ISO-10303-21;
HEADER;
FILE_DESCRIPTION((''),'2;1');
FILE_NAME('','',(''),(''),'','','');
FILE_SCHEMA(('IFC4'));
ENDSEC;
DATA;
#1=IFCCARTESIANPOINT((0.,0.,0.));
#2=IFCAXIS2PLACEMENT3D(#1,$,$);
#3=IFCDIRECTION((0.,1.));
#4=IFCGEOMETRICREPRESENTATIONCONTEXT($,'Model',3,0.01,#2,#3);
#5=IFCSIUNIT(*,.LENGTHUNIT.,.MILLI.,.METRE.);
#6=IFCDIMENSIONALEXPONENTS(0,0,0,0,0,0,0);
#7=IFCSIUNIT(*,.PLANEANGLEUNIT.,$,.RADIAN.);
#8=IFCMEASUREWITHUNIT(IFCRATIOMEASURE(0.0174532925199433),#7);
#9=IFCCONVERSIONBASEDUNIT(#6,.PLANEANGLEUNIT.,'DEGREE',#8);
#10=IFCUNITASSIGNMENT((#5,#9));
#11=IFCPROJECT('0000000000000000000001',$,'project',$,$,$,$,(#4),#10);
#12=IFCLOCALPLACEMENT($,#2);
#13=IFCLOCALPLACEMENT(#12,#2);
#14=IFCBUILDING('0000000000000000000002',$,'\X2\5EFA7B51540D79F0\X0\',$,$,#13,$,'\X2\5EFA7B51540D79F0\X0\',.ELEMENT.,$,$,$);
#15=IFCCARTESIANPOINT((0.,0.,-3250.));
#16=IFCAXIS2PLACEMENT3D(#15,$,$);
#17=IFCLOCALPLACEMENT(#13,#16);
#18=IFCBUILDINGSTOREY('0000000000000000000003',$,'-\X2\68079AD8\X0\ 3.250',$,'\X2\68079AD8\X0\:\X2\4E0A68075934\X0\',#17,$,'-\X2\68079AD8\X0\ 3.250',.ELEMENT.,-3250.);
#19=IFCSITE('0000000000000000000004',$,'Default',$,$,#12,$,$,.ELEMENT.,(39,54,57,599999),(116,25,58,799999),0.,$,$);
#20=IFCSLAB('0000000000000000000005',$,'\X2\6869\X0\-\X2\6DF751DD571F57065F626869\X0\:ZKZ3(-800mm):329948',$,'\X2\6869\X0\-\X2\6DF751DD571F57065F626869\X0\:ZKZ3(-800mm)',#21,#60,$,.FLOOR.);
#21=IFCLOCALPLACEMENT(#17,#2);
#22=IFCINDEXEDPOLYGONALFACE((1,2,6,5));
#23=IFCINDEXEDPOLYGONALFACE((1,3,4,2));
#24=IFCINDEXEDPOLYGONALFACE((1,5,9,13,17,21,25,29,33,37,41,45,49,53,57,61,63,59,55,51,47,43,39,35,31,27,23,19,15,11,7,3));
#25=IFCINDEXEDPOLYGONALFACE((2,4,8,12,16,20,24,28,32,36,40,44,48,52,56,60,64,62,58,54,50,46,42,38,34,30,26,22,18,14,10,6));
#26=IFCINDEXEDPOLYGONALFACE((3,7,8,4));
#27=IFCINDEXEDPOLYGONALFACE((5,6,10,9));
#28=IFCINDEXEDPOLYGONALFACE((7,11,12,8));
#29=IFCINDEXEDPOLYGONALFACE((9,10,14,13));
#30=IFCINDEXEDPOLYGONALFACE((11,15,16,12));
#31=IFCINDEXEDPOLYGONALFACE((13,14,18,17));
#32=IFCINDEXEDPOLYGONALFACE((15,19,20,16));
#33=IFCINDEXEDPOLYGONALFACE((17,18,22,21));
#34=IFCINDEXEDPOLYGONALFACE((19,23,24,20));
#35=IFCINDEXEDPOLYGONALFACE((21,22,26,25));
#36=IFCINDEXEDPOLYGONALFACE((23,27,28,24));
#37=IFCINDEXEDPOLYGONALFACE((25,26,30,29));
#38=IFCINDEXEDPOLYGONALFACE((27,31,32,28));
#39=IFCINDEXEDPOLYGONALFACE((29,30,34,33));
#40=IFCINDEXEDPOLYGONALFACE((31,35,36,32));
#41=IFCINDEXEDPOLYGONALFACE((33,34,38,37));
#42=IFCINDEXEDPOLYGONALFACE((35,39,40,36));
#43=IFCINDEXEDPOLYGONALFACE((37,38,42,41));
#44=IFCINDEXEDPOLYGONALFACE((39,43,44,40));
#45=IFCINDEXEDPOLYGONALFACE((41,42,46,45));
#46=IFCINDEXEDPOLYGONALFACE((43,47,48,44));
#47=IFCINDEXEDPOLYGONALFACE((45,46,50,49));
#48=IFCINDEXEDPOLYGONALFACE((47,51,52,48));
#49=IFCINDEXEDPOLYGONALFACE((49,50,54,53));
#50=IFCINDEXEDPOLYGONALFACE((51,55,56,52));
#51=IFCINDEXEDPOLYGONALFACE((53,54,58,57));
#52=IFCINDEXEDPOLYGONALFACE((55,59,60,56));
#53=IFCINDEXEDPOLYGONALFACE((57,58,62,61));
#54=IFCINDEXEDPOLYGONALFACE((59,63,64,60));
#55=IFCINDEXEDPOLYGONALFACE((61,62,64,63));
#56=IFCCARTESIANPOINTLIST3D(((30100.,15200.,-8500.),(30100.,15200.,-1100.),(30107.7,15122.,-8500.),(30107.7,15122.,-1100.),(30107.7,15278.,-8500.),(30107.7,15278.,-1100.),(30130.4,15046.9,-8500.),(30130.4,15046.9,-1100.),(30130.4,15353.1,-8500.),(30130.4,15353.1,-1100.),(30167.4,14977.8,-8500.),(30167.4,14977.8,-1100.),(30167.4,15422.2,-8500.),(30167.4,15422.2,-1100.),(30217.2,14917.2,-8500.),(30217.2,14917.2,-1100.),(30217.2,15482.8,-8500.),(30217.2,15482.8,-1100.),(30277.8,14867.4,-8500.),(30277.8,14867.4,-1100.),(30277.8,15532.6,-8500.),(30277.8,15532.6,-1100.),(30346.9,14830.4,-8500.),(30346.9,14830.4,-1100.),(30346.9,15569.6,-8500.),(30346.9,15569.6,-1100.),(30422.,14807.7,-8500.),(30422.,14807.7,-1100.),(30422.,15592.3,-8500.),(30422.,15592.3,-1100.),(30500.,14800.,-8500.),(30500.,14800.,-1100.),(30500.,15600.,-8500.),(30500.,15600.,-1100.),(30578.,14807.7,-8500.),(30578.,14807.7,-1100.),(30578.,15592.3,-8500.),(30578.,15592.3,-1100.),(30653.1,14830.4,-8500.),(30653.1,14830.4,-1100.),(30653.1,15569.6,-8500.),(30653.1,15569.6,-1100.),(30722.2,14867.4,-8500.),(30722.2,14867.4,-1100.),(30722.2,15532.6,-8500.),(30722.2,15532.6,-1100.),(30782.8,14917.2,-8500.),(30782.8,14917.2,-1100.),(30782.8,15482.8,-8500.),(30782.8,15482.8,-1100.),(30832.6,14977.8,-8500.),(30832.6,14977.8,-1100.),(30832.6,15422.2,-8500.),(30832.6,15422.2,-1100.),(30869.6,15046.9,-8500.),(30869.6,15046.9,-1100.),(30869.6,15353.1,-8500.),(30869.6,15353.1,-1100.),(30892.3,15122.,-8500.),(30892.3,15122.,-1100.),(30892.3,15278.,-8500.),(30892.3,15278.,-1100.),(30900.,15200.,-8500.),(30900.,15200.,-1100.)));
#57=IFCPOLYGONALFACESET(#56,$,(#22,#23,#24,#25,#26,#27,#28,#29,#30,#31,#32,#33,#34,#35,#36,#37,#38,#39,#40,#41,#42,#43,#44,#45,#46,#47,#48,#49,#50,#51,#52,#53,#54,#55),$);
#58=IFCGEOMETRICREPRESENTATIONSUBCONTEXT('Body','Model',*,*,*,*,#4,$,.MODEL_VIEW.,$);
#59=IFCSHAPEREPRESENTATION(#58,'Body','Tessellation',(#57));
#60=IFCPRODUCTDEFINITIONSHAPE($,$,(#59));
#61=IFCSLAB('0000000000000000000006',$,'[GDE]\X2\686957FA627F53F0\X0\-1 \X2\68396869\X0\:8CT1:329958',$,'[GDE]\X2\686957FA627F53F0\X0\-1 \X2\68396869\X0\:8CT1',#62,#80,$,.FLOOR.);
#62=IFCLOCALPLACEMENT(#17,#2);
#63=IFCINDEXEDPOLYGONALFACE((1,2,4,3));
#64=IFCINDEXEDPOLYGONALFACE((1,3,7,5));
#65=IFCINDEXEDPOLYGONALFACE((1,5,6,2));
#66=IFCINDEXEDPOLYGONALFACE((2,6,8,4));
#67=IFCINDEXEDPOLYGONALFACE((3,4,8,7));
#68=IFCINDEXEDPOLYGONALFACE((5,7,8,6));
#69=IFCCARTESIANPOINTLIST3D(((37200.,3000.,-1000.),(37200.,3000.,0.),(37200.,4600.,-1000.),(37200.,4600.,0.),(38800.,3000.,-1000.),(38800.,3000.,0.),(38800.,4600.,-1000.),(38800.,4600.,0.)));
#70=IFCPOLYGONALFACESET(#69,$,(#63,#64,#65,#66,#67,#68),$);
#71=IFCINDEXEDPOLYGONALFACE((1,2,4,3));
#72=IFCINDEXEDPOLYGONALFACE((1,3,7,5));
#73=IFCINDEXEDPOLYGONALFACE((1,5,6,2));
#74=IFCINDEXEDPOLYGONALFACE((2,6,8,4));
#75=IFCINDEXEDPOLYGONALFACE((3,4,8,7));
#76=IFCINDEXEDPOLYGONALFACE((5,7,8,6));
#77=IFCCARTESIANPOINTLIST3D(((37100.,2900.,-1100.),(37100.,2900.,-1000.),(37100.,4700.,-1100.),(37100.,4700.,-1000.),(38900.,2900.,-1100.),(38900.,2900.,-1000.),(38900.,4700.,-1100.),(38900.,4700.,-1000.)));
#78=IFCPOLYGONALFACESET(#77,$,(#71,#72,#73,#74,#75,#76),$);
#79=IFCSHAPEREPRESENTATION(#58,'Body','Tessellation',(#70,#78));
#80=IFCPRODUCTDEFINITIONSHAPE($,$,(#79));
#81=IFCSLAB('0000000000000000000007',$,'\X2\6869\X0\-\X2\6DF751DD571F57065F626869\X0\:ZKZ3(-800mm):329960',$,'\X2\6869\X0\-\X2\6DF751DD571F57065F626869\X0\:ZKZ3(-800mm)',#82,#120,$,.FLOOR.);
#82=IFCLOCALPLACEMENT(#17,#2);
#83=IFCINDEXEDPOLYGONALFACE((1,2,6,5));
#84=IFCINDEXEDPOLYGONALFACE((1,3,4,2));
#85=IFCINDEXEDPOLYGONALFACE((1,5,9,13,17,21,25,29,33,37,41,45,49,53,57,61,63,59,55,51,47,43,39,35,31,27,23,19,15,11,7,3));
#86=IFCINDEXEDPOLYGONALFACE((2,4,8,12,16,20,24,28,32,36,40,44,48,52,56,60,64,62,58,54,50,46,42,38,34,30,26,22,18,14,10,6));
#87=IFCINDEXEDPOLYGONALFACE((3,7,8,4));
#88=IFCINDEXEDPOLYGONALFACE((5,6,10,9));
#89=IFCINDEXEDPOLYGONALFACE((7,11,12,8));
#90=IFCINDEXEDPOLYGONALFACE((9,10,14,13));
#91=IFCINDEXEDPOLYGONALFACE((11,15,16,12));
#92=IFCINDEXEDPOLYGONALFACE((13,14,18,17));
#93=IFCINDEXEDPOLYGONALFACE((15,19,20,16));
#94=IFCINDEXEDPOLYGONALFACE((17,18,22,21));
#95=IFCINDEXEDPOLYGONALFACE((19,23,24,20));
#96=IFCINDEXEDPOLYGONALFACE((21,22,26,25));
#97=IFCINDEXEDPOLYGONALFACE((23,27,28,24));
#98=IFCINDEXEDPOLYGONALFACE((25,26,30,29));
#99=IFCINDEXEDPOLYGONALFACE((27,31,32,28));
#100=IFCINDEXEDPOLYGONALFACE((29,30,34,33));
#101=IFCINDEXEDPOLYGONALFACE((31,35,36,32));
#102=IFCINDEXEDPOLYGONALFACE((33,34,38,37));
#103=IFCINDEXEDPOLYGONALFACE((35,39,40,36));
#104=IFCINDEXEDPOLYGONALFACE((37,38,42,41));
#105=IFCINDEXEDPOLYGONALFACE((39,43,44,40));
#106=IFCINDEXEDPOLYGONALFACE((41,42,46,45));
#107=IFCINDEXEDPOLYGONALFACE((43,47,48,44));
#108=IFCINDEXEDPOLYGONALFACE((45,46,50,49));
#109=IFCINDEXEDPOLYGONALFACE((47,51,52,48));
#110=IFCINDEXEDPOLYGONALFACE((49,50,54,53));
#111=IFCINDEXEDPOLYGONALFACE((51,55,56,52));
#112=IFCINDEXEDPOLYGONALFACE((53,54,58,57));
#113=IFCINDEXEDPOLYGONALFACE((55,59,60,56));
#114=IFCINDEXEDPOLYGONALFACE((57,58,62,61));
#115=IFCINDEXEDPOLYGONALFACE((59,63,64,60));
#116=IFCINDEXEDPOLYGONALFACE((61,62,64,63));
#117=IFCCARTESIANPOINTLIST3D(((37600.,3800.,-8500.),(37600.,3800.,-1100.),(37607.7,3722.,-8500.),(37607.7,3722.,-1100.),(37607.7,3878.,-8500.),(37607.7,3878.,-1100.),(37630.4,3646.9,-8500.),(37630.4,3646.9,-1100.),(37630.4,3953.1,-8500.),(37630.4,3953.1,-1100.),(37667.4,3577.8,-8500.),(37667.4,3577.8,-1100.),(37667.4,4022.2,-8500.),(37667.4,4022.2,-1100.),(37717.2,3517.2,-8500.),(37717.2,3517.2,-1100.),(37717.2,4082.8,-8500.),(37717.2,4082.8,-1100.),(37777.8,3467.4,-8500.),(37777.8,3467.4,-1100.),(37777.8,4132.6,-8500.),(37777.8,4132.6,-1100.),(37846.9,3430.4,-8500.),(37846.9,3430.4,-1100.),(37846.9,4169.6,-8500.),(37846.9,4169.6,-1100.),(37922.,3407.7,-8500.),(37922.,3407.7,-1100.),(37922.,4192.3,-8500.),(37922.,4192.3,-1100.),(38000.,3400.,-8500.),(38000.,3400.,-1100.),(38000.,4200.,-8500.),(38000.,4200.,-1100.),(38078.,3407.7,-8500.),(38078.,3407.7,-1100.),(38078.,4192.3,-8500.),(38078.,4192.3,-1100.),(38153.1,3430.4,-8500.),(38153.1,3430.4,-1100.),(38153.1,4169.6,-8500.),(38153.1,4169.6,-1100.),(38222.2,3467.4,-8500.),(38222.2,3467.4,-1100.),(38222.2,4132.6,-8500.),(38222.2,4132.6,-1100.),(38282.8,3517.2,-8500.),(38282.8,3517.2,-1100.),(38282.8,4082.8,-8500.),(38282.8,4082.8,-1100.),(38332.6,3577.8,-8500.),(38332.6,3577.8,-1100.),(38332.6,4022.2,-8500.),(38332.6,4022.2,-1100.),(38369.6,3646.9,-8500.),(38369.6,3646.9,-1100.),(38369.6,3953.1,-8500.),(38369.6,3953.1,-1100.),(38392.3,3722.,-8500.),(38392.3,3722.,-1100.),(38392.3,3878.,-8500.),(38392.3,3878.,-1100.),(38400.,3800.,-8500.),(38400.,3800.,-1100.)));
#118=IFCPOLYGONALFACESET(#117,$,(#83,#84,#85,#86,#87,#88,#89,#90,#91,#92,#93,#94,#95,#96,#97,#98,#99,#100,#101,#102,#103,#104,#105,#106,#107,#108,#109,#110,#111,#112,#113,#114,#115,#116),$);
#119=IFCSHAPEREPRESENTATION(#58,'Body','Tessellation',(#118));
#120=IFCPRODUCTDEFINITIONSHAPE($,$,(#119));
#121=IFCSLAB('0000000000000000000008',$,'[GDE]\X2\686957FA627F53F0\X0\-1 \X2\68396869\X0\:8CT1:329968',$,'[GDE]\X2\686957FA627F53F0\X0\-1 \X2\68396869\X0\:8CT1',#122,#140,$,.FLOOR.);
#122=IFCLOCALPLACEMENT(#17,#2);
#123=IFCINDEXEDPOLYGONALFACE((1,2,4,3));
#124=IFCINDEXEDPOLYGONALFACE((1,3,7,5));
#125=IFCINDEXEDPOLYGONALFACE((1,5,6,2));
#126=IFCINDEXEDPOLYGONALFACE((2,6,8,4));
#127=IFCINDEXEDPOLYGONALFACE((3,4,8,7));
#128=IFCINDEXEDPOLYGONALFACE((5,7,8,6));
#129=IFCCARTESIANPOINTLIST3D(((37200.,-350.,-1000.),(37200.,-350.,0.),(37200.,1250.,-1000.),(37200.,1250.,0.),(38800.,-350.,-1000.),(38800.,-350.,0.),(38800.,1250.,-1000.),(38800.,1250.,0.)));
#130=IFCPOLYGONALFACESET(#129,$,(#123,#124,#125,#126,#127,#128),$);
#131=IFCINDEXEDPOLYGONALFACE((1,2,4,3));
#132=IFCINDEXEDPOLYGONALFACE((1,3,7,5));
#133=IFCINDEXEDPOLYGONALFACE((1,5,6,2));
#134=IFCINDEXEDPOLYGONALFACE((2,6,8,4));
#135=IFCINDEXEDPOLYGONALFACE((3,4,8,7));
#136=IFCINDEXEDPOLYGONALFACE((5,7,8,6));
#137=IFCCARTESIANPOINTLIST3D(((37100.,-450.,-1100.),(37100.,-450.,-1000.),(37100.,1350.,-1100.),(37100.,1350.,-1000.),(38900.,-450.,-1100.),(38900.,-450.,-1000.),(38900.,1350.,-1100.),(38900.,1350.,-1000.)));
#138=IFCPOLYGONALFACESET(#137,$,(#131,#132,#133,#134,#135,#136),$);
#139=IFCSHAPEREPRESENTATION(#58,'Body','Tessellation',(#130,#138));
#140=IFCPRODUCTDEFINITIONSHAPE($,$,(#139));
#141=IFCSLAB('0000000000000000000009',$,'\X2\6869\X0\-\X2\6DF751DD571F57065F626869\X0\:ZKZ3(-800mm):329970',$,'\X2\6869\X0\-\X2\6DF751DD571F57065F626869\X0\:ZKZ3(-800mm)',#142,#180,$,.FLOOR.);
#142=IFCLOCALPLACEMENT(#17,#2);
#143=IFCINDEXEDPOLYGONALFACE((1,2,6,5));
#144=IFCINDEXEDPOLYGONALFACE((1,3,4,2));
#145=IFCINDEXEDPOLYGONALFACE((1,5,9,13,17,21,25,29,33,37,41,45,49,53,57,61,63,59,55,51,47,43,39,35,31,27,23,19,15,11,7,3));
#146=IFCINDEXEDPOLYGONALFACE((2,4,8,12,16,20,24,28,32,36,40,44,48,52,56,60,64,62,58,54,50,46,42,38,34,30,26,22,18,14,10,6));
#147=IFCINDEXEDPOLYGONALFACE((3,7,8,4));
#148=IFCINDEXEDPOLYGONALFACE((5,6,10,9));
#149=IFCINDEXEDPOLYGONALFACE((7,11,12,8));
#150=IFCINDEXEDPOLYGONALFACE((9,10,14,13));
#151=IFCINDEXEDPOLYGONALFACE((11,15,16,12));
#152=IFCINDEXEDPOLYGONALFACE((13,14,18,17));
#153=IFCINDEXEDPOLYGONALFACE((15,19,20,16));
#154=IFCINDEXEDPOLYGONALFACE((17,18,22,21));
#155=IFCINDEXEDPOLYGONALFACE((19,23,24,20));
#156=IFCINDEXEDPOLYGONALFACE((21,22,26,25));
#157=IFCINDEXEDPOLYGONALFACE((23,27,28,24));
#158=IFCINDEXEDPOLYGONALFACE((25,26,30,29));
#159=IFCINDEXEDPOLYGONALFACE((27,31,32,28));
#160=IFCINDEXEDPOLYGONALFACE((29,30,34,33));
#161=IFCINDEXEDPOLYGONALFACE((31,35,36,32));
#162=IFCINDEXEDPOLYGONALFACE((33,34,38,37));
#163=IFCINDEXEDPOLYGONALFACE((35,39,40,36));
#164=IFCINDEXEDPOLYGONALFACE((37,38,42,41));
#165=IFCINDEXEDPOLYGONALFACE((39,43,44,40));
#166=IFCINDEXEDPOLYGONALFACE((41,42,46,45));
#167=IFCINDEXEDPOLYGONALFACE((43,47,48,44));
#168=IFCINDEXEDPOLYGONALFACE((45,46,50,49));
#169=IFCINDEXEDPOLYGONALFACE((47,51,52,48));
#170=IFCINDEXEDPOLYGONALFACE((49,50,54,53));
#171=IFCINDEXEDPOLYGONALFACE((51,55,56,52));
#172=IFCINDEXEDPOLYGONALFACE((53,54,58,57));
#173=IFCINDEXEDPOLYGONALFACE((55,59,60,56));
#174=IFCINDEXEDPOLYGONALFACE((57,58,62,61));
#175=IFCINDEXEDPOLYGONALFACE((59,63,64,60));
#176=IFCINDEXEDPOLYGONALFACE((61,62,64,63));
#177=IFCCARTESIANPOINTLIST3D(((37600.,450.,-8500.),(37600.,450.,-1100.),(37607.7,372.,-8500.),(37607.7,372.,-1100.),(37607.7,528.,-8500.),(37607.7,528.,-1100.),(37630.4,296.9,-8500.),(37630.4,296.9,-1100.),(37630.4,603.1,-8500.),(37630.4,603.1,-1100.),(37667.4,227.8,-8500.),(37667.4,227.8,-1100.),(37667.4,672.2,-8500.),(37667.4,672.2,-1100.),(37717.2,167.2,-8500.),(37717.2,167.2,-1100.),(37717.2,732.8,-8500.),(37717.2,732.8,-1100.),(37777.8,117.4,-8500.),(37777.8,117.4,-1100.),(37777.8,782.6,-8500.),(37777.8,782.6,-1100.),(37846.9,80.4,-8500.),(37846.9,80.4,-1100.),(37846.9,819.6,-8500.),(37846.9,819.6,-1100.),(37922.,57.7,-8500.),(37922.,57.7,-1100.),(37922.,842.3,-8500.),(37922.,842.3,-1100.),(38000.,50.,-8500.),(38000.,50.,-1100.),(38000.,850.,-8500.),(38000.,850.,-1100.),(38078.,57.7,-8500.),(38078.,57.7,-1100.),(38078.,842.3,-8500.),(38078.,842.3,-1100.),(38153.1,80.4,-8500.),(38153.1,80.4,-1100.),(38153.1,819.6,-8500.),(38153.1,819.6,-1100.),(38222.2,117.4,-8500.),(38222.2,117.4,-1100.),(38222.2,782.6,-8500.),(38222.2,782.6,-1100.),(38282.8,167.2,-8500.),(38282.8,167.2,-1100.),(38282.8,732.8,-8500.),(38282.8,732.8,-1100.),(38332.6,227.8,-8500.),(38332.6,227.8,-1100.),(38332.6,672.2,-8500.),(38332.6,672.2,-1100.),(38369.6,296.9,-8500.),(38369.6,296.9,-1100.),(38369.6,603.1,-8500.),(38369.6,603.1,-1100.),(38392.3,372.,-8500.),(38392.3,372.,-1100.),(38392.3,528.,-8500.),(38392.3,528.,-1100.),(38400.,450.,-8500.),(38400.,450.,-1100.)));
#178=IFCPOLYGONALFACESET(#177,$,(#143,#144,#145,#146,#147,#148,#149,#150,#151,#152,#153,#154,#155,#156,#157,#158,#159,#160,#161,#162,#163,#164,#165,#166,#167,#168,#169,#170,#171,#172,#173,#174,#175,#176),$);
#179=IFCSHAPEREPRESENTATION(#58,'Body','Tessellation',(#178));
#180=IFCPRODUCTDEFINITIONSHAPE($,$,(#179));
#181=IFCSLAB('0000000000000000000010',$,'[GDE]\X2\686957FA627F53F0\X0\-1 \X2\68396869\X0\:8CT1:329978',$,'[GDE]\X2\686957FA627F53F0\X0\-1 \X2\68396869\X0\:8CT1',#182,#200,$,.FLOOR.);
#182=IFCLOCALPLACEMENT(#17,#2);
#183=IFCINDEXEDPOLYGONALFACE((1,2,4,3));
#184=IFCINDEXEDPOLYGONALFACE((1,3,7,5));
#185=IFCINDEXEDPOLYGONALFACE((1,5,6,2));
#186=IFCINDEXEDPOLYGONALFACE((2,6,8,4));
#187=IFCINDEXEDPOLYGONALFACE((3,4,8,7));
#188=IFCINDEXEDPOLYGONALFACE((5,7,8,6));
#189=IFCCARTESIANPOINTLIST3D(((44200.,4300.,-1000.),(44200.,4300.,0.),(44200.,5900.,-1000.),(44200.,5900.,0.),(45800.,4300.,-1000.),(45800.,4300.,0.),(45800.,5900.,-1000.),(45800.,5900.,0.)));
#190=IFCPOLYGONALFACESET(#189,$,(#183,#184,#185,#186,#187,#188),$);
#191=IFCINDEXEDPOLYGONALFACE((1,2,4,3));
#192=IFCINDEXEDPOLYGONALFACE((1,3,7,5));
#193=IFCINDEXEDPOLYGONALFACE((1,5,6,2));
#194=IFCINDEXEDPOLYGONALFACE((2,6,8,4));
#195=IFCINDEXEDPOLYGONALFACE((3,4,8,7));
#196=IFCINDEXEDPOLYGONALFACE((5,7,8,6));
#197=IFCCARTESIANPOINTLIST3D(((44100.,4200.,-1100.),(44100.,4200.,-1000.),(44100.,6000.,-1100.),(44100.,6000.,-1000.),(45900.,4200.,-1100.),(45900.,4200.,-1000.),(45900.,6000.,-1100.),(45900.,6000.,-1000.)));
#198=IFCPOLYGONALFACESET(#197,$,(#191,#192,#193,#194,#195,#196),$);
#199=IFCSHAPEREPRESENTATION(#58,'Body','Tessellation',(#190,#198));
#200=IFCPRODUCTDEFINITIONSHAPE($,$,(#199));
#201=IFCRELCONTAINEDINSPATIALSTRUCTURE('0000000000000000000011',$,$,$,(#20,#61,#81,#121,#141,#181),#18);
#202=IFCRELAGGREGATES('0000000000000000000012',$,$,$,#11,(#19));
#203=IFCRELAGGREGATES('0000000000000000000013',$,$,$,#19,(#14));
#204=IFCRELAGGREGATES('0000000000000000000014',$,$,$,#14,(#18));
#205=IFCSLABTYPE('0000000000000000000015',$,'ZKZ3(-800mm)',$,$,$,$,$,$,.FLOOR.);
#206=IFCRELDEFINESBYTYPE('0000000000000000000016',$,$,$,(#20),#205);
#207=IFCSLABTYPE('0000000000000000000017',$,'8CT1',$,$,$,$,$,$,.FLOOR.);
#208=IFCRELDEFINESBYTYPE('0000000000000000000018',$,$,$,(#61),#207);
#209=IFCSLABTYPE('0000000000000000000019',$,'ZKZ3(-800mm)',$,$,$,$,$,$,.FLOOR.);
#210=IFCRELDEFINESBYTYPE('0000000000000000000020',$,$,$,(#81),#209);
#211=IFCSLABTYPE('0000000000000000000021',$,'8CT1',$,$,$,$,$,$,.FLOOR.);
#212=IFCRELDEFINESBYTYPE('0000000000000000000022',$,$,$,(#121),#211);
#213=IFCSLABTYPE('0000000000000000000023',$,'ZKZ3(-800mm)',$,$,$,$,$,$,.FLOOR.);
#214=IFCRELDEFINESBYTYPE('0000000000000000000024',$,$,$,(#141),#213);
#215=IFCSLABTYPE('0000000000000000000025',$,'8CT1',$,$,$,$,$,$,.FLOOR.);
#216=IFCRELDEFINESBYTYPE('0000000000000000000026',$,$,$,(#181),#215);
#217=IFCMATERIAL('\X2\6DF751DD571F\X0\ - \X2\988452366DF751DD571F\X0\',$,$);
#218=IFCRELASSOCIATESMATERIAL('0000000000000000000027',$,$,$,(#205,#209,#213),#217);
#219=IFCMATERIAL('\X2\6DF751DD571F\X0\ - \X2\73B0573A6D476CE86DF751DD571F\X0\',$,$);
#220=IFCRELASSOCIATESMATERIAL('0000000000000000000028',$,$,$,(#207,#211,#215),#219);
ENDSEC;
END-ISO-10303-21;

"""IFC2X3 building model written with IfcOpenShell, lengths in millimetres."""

from ifc_helpers import new_model, entity, si_unit, converted_unit, direction, frame, frame_2d, origin, origin_2d_with_axis, place, context, subcontext, project, spatial, rectangle, circle, extrude, material, type_object, element, save


model = new_model("IFC2X3")

# Units and contexts
model_context = context("Model", 3, precision=0.01, world=origin(), true_north=direction((0.0, 1.0)))
body_context = subcontext(model_context, "Body", "Model", "MODEL_VIEW")
ifc_project = project(units=[si_unit("LENGTHUNIT", "METRE", prefix="MILLI"), converted_unit("PLANEANGLEUNIT", "DEGREE", entity("IfcRatioMeasure", 0.0174532925199433), si_unit("PLANEANGLEUNIT", "RADIAN"), dimensions=[0, 0, 0, 0, 0, 0, 0])], contexts=[model_context])

# Site, building, storey
site_placement = place(None, origin())
site = spatial("IfcSite", under=ifc_project, at=site_placement, Name="Default", CompositionType="ELEMENT", RefLatitude=(39, 54, 57, 599999), RefLongitude=(116, 25, 58, 799999), RefElevation=0.0)
building_placement = place(site_placement, origin())
building = spatial("IfcBuilding", under=site, at=building_placement, Name="建筑名称", LongName="建筑名称", CompositionType="ELEMENT")
storey_placement = place(building_placement, frame((0.0, 0.0, -3250.0)))
storey = spatial("IfcBuildingStorey", under=building, at=storey_placement, Name="-标高 3.250", ObjectType="标高:上标头", LongName="-标高 3.250", CompositionType="ELEMENT", Elevation=-3250.0)

# Slabs
ifc_material_1 = material(Name="混凝土 - 现场浇注混凝土")
ifc_material_2 = material(Name="混凝土 - 预制混凝土")
slab_type_1 = type_object("IfcSlabType", Name="ZKZ3(-800mm)", PredefinedType="FLOOR", material=ifc_material_2)
slab_1_placement = place(storey_placement, origin())
element("IfcSlab", 1, at=slab_1_placement, inside=storey, type_object=slab_type_1, Name="桩-混凝土圆形桩:ZKZ3(-800mm):329948", ObjectType="桩-混凝土圆形桩:ZKZ3(-800mm)", PredefinedType="FLOOR", context=body_context, shape_type="SweptSolid", body=[
    extrude(circle(Radius=400.0, at=frame_2d((0.0, 0.0), x_axis=(1.0, 0.0))), frame((30500.0, 15200.0, -8500.0)), (0.0, 0.0, 1.0), 7400.0),
])
slab_type_2 = type_object("IfcSlabType", Name="8CT1", PredefinedType="FLOOR", material=ifc_material_1)
slab_2_placement = place(storey_placement, origin())
element("IfcSlab", 2, at=slab_2_placement, inside=storey, type_object=slab_type_2, Name="[GDE]桩基承台-1 根桩:8CT1:329958", ObjectType="[GDE]桩基承台-1 根桩:8CT1", PredefinedType="FLOOR", context=body_context, shape_type="SweptSolid", body=[
    extrude(rectangle(XDim=1600.0, YDim=1600.0, at=origin_2d_with_axis()), frame((38000.0, 3800.0, -1000.0), z_axis=(0.0, 0.0, 1.0), x_axis=(-1.0, 0.0, 0.0)), (0.0, 0.0, 1.0), 1000.0),
    extrude(rectangle(XDim=1800.0, YDim=1800.0, at=origin_2d_with_axis()), frame((38000.0, 3800.0, -1100.0), z_axis=(0.0, 0.0, 1.0), x_axis=(-1.0, 0.0, 0.0)), (0.0, 0.0, 1.0), 100.0),
])
slab_type_3 = type_object("IfcSlabType", Name="ZKZ3(-800mm)", PredefinedType="FLOOR", material=ifc_material_2)
slab_3_placement = place(storey_placement, origin())
element("IfcSlab", 3, at=slab_3_placement, inside=storey, type_object=slab_type_3, Name="桩-混凝土圆形桩:ZKZ3(-800mm):329960", ObjectType="桩-混凝土圆形桩:ZKZ3(-800mm)", PredefinedType="FLOOR", context=body_context, shape_type="SweptSolid", body=[
    extrude(circle(Radius=400.0, at=frame_2d((0.0, 0.0), x_axis=(1.0, 0.0))), frame((38000.0, 3800.0, -8500.0)), (0.0, 0.0, 1.0), 7400.0),
])
slab_type_4 = type_object("IfcSlabType", Name="8CT1", PredefinedType="FLOOR", material=ifc_material_1)
slab_4_placement = place(storey_placement, origin())
element("IfcSlab", 4, at=slab_4_placement, inside=storey, type_object=slab_type_4, Name="[GDE]桩基承台-1 根桩:8CT1:329968", ObjectType="[GDE]桩基承台-1 根桩:8CT1", PredefinedType="FLOOR", context=body_context, shape_type="SweptSolid", body=[
    extrude(rectangle(XDim=1600.0, YDim=1600.0, at=origin_2d_with_axis()), frame((38000.0, 450.0, -1000.0), z_axis=(0.0, 0.0, 1.0), x_axis=(-1.0, 0.0, 0.0)), (0.0, 0.0, 1.0), 1000.0),
    extrude(rectangle(XDim=1800.0, YDim=1800.0, at=origin_2d_with_axis()), frame((38000.0, 450.0, -1100.0), z_axis=(0.0, 0.0, 1.0), x_axis=(-1.0, 0.0, 0.0)), (0.0, 0.0, 1.0), 100.0),
])
slab_type_5 = type_object("IfcSlabType", Name="ZKZ3(-800mm)", PredefinedType="FLOOR", material=ifc_material_2)
slab_5_placement = place(storey_placement, origin())
element("IfcSlab", 5, at=slab_5_placement, inside=storey, type_object=slab_type_5, Name="桩-混凝土圆形桩:ZKZ3(-800mm):329970", ObjectType="桩-混凝土圆形桩:ZKZ3(-800mm)", PredefinedType="FLOOR", context=body_context, shape_type="SweptSolid", body=[
    extrude(circle(Radius=400.0, at=frame_2d((0.0, 0.0), x_axis=(1.0, 0.0))), frame((38000.0, 450.0, -8500.0)), (0.0, 0.0, 1.0), 7400.0),
])
slab_type_6 = type_object("IfcSlabType", Name="8CT1", PredefinedType="FLOOR", material=ifc_material_1)
slab_6_placement = place(storey_placement, origin())
element("IfcSlab", 6, at=slab_6_placement, inside=storey, type_object=slab_type_6, Name="[GDE]桩基承台-1 根桩:8CT1:329978", ObjectType="[GDE]桩基承台-1 根桩:8CT1", PredefinedType="FLOOR", context=body_context, shape_type="SweptSolid", body=[
    extrude(rectangle(XDim=1600.0, YDim=1600.0, at=origin_2d_with_axis()), frame((45000.0, 5100.0, -1000.0), z_axis=(0.0, 0.0, 1.0), x_axis=(-1.0, 0.0, 0.0)), (0.0, 0.0, 1.0), 1000.0),
    extrude(rectangle(XDim=1800.0, YDim=1800.0, at=frame_2d((0.0, 0.0), x_axis=(1.0, 0.0))), frame((45000.0, 5100.0, -1100.0), z_axis=(0.0, 0.0, 1.0), x_axis=(-1.0, 0.0, 0.0)), (0.0, 0.0, 1.0), 100.0),
])

save(model, "model.ifc")
